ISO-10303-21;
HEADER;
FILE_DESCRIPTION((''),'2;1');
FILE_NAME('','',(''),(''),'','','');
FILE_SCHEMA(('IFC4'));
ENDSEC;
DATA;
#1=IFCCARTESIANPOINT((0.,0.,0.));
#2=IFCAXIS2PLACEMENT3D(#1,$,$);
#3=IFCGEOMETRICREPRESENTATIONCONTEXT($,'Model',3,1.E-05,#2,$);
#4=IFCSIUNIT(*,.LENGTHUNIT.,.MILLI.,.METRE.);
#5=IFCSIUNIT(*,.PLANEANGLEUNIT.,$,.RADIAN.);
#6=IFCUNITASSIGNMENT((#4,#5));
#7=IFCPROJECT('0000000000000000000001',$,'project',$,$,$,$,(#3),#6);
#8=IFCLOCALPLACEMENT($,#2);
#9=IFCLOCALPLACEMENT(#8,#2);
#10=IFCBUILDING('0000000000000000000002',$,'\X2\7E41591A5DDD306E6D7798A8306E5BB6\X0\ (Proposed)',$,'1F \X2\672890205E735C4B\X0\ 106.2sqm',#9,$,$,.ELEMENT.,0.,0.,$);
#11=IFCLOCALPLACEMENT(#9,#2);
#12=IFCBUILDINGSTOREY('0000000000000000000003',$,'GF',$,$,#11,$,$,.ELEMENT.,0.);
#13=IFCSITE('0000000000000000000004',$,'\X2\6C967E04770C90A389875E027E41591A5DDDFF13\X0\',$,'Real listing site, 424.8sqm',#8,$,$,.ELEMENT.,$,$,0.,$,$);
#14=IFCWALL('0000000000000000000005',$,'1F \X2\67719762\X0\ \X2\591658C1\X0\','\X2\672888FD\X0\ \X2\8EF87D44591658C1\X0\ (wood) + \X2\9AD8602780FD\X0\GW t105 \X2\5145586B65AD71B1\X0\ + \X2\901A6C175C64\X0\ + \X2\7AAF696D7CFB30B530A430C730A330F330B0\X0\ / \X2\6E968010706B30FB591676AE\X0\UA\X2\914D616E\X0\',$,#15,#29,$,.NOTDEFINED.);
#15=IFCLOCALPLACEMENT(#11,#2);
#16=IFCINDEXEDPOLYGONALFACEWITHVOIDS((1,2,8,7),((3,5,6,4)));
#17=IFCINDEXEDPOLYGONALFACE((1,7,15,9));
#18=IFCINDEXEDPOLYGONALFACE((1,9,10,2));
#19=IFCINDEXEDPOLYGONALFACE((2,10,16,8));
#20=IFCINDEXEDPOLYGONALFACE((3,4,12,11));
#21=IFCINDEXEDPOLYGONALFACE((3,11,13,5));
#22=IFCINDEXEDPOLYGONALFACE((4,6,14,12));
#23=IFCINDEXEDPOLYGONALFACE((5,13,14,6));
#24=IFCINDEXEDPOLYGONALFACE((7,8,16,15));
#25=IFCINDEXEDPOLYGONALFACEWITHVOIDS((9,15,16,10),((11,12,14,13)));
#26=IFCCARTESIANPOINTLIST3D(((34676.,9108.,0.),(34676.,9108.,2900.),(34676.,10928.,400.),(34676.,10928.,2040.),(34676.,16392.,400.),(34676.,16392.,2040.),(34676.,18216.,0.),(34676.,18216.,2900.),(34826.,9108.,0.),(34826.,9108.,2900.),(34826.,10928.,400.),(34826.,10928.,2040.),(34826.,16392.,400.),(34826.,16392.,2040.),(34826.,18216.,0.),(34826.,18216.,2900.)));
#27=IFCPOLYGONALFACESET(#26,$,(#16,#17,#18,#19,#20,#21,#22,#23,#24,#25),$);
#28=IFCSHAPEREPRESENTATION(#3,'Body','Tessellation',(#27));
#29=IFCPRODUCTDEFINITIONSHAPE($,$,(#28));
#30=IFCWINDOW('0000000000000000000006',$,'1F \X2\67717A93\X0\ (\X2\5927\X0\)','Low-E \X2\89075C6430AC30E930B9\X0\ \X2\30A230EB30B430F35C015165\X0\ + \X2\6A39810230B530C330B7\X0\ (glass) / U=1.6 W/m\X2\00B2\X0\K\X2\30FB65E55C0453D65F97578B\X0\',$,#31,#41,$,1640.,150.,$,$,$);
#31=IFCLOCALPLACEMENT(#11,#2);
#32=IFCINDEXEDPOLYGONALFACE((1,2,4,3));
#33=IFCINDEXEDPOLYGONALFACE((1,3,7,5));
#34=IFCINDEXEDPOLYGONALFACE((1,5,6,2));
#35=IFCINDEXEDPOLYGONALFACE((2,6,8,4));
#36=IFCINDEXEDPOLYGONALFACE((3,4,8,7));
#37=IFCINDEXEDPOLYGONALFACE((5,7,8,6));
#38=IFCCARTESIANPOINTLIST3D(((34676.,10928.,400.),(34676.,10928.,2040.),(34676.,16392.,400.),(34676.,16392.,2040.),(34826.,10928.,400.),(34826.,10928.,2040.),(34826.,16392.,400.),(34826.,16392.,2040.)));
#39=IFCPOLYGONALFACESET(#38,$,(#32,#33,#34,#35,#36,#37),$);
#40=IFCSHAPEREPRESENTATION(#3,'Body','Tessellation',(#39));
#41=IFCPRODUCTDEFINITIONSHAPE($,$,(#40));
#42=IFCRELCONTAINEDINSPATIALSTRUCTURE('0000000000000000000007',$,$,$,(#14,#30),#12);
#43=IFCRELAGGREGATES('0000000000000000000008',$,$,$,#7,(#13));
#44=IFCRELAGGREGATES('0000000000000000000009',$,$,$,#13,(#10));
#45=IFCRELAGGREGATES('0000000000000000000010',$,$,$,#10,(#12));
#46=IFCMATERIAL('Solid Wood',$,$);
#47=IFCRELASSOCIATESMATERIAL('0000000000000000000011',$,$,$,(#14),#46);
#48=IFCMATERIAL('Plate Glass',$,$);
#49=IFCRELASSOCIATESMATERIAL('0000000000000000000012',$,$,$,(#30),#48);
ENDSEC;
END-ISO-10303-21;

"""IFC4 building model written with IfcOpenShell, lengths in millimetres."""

from ifc_helpers import new_model, si_unit, frame, frame_2d, origin, place, context, project, spatial, rectangle, extrude, material, element, fill, save


model = new_model("IFC4")

# Units and contexts
model_context = context("Model", 3, precision=1e-05, world=origin())
ifc_project = project(units=[si_unit("LENGTHUNIT", "METRE", prefix="MILLI"), si_unit("PLANEANGLEUNIT", "RADIAN")], contexts=[model_context])

# Site, building, storey
site_placement = place(None, origin())
site = spatial("IfcSite", under=ifc_project, at=site_placement, Name="沖縄県那覇市繁多川３", ObjectType="Real listing site, 424.8sqm", CompositionType="ELEMENT", RefElevation=0.0)
building_placement = place(site_placement, origin())
building = spatial("IfcBuilding", under=site, at=building_placement, Name="繁多川の海風の家 (Proposed)", ObjectType="1F 木造平屋 106.2sqm", CompositionType="ELEMENT", ElevationOfRefHeight=0.0, ElevationOfTerrain=0.0)
storey_placement = place(building_placement, origin())
storey = spatial("IfcBuildingStorey", under=building, at=storey_placement, Name="GF", CompositionType="ELEMENT", Elevation=0.0)

# Wall, opening, window
ifc_material_1 = material(Name="Solid Wood")
wall_1_placement = place(storey_placement, frame((17338.0, 4554.0, 0.0)))
wall_1 = element("IfcWall", 1, at=wall_1_placement, inside=storey, material=ifc_material_1, Name="1F 東面 外壁", Description="木製 軸組外壁 (wood) + 高性能GW t105 充填断熱 + 通気層 + 窯業系サイディング / 準耐火・外皮UA配慮", PredefinedType="NOTDEFINED", context=model_context, shape_type="SweptSolid", body=[
    extrude(rectangle(XDim=150.0, YDim=9108.0, at=frame_2d((75.0, 4554.0))), frame((17338.0, 4554.0, 0.0)), (0.0, 0.0, 1.0), 2900.0),
])
opening_placement = place(storey_placement, frame((17338.0, 5464.0, 200.0)))
opening = element("IfcOpeningElement", 2, at=opening_placement, cuts=wall_1, PredefinedType="NOTDEFINED", context=model_context, shape_type="SweptSolid", body=[
    extrude(rectangle(XDim=150.0, YDim=5464.0, at=frame_2d((75.0, 2732.0))), frame((17338.0, 5464.0, 200.0)), (0.0, 0.0, 1.0), 1640.0),
])
ifc_material_2 = material(Name="Plate Glass")
window_1_placement = place(storey_placement, frame((17338.0, 5464.0, 200.0)))
window_1 = element("IfcWindow", 3, at=window_1_placement, inside=storey, material=ifc_material_2, Name="1F 東窓 (大)", Description="Low-E 複層ガラス アルゴン封入 + 樹脂サッシ (glass) / U=1.6 W/m²K・日射取得型", OverallHeight=1640.0, OverallWidth=150.0, context=model_context, shape_type="SweptSolid", body=[
    extrude(rectangle(XDim=150.0, YDim=5464.0, at=frame_2d((75.0, 2732.0))), frame((17338.0, 5464.0, 200.0)), (0.0, 0.0, 1.0), 1640.0),
])
fill(opening, window_1)

save(model, "model.ifc")
